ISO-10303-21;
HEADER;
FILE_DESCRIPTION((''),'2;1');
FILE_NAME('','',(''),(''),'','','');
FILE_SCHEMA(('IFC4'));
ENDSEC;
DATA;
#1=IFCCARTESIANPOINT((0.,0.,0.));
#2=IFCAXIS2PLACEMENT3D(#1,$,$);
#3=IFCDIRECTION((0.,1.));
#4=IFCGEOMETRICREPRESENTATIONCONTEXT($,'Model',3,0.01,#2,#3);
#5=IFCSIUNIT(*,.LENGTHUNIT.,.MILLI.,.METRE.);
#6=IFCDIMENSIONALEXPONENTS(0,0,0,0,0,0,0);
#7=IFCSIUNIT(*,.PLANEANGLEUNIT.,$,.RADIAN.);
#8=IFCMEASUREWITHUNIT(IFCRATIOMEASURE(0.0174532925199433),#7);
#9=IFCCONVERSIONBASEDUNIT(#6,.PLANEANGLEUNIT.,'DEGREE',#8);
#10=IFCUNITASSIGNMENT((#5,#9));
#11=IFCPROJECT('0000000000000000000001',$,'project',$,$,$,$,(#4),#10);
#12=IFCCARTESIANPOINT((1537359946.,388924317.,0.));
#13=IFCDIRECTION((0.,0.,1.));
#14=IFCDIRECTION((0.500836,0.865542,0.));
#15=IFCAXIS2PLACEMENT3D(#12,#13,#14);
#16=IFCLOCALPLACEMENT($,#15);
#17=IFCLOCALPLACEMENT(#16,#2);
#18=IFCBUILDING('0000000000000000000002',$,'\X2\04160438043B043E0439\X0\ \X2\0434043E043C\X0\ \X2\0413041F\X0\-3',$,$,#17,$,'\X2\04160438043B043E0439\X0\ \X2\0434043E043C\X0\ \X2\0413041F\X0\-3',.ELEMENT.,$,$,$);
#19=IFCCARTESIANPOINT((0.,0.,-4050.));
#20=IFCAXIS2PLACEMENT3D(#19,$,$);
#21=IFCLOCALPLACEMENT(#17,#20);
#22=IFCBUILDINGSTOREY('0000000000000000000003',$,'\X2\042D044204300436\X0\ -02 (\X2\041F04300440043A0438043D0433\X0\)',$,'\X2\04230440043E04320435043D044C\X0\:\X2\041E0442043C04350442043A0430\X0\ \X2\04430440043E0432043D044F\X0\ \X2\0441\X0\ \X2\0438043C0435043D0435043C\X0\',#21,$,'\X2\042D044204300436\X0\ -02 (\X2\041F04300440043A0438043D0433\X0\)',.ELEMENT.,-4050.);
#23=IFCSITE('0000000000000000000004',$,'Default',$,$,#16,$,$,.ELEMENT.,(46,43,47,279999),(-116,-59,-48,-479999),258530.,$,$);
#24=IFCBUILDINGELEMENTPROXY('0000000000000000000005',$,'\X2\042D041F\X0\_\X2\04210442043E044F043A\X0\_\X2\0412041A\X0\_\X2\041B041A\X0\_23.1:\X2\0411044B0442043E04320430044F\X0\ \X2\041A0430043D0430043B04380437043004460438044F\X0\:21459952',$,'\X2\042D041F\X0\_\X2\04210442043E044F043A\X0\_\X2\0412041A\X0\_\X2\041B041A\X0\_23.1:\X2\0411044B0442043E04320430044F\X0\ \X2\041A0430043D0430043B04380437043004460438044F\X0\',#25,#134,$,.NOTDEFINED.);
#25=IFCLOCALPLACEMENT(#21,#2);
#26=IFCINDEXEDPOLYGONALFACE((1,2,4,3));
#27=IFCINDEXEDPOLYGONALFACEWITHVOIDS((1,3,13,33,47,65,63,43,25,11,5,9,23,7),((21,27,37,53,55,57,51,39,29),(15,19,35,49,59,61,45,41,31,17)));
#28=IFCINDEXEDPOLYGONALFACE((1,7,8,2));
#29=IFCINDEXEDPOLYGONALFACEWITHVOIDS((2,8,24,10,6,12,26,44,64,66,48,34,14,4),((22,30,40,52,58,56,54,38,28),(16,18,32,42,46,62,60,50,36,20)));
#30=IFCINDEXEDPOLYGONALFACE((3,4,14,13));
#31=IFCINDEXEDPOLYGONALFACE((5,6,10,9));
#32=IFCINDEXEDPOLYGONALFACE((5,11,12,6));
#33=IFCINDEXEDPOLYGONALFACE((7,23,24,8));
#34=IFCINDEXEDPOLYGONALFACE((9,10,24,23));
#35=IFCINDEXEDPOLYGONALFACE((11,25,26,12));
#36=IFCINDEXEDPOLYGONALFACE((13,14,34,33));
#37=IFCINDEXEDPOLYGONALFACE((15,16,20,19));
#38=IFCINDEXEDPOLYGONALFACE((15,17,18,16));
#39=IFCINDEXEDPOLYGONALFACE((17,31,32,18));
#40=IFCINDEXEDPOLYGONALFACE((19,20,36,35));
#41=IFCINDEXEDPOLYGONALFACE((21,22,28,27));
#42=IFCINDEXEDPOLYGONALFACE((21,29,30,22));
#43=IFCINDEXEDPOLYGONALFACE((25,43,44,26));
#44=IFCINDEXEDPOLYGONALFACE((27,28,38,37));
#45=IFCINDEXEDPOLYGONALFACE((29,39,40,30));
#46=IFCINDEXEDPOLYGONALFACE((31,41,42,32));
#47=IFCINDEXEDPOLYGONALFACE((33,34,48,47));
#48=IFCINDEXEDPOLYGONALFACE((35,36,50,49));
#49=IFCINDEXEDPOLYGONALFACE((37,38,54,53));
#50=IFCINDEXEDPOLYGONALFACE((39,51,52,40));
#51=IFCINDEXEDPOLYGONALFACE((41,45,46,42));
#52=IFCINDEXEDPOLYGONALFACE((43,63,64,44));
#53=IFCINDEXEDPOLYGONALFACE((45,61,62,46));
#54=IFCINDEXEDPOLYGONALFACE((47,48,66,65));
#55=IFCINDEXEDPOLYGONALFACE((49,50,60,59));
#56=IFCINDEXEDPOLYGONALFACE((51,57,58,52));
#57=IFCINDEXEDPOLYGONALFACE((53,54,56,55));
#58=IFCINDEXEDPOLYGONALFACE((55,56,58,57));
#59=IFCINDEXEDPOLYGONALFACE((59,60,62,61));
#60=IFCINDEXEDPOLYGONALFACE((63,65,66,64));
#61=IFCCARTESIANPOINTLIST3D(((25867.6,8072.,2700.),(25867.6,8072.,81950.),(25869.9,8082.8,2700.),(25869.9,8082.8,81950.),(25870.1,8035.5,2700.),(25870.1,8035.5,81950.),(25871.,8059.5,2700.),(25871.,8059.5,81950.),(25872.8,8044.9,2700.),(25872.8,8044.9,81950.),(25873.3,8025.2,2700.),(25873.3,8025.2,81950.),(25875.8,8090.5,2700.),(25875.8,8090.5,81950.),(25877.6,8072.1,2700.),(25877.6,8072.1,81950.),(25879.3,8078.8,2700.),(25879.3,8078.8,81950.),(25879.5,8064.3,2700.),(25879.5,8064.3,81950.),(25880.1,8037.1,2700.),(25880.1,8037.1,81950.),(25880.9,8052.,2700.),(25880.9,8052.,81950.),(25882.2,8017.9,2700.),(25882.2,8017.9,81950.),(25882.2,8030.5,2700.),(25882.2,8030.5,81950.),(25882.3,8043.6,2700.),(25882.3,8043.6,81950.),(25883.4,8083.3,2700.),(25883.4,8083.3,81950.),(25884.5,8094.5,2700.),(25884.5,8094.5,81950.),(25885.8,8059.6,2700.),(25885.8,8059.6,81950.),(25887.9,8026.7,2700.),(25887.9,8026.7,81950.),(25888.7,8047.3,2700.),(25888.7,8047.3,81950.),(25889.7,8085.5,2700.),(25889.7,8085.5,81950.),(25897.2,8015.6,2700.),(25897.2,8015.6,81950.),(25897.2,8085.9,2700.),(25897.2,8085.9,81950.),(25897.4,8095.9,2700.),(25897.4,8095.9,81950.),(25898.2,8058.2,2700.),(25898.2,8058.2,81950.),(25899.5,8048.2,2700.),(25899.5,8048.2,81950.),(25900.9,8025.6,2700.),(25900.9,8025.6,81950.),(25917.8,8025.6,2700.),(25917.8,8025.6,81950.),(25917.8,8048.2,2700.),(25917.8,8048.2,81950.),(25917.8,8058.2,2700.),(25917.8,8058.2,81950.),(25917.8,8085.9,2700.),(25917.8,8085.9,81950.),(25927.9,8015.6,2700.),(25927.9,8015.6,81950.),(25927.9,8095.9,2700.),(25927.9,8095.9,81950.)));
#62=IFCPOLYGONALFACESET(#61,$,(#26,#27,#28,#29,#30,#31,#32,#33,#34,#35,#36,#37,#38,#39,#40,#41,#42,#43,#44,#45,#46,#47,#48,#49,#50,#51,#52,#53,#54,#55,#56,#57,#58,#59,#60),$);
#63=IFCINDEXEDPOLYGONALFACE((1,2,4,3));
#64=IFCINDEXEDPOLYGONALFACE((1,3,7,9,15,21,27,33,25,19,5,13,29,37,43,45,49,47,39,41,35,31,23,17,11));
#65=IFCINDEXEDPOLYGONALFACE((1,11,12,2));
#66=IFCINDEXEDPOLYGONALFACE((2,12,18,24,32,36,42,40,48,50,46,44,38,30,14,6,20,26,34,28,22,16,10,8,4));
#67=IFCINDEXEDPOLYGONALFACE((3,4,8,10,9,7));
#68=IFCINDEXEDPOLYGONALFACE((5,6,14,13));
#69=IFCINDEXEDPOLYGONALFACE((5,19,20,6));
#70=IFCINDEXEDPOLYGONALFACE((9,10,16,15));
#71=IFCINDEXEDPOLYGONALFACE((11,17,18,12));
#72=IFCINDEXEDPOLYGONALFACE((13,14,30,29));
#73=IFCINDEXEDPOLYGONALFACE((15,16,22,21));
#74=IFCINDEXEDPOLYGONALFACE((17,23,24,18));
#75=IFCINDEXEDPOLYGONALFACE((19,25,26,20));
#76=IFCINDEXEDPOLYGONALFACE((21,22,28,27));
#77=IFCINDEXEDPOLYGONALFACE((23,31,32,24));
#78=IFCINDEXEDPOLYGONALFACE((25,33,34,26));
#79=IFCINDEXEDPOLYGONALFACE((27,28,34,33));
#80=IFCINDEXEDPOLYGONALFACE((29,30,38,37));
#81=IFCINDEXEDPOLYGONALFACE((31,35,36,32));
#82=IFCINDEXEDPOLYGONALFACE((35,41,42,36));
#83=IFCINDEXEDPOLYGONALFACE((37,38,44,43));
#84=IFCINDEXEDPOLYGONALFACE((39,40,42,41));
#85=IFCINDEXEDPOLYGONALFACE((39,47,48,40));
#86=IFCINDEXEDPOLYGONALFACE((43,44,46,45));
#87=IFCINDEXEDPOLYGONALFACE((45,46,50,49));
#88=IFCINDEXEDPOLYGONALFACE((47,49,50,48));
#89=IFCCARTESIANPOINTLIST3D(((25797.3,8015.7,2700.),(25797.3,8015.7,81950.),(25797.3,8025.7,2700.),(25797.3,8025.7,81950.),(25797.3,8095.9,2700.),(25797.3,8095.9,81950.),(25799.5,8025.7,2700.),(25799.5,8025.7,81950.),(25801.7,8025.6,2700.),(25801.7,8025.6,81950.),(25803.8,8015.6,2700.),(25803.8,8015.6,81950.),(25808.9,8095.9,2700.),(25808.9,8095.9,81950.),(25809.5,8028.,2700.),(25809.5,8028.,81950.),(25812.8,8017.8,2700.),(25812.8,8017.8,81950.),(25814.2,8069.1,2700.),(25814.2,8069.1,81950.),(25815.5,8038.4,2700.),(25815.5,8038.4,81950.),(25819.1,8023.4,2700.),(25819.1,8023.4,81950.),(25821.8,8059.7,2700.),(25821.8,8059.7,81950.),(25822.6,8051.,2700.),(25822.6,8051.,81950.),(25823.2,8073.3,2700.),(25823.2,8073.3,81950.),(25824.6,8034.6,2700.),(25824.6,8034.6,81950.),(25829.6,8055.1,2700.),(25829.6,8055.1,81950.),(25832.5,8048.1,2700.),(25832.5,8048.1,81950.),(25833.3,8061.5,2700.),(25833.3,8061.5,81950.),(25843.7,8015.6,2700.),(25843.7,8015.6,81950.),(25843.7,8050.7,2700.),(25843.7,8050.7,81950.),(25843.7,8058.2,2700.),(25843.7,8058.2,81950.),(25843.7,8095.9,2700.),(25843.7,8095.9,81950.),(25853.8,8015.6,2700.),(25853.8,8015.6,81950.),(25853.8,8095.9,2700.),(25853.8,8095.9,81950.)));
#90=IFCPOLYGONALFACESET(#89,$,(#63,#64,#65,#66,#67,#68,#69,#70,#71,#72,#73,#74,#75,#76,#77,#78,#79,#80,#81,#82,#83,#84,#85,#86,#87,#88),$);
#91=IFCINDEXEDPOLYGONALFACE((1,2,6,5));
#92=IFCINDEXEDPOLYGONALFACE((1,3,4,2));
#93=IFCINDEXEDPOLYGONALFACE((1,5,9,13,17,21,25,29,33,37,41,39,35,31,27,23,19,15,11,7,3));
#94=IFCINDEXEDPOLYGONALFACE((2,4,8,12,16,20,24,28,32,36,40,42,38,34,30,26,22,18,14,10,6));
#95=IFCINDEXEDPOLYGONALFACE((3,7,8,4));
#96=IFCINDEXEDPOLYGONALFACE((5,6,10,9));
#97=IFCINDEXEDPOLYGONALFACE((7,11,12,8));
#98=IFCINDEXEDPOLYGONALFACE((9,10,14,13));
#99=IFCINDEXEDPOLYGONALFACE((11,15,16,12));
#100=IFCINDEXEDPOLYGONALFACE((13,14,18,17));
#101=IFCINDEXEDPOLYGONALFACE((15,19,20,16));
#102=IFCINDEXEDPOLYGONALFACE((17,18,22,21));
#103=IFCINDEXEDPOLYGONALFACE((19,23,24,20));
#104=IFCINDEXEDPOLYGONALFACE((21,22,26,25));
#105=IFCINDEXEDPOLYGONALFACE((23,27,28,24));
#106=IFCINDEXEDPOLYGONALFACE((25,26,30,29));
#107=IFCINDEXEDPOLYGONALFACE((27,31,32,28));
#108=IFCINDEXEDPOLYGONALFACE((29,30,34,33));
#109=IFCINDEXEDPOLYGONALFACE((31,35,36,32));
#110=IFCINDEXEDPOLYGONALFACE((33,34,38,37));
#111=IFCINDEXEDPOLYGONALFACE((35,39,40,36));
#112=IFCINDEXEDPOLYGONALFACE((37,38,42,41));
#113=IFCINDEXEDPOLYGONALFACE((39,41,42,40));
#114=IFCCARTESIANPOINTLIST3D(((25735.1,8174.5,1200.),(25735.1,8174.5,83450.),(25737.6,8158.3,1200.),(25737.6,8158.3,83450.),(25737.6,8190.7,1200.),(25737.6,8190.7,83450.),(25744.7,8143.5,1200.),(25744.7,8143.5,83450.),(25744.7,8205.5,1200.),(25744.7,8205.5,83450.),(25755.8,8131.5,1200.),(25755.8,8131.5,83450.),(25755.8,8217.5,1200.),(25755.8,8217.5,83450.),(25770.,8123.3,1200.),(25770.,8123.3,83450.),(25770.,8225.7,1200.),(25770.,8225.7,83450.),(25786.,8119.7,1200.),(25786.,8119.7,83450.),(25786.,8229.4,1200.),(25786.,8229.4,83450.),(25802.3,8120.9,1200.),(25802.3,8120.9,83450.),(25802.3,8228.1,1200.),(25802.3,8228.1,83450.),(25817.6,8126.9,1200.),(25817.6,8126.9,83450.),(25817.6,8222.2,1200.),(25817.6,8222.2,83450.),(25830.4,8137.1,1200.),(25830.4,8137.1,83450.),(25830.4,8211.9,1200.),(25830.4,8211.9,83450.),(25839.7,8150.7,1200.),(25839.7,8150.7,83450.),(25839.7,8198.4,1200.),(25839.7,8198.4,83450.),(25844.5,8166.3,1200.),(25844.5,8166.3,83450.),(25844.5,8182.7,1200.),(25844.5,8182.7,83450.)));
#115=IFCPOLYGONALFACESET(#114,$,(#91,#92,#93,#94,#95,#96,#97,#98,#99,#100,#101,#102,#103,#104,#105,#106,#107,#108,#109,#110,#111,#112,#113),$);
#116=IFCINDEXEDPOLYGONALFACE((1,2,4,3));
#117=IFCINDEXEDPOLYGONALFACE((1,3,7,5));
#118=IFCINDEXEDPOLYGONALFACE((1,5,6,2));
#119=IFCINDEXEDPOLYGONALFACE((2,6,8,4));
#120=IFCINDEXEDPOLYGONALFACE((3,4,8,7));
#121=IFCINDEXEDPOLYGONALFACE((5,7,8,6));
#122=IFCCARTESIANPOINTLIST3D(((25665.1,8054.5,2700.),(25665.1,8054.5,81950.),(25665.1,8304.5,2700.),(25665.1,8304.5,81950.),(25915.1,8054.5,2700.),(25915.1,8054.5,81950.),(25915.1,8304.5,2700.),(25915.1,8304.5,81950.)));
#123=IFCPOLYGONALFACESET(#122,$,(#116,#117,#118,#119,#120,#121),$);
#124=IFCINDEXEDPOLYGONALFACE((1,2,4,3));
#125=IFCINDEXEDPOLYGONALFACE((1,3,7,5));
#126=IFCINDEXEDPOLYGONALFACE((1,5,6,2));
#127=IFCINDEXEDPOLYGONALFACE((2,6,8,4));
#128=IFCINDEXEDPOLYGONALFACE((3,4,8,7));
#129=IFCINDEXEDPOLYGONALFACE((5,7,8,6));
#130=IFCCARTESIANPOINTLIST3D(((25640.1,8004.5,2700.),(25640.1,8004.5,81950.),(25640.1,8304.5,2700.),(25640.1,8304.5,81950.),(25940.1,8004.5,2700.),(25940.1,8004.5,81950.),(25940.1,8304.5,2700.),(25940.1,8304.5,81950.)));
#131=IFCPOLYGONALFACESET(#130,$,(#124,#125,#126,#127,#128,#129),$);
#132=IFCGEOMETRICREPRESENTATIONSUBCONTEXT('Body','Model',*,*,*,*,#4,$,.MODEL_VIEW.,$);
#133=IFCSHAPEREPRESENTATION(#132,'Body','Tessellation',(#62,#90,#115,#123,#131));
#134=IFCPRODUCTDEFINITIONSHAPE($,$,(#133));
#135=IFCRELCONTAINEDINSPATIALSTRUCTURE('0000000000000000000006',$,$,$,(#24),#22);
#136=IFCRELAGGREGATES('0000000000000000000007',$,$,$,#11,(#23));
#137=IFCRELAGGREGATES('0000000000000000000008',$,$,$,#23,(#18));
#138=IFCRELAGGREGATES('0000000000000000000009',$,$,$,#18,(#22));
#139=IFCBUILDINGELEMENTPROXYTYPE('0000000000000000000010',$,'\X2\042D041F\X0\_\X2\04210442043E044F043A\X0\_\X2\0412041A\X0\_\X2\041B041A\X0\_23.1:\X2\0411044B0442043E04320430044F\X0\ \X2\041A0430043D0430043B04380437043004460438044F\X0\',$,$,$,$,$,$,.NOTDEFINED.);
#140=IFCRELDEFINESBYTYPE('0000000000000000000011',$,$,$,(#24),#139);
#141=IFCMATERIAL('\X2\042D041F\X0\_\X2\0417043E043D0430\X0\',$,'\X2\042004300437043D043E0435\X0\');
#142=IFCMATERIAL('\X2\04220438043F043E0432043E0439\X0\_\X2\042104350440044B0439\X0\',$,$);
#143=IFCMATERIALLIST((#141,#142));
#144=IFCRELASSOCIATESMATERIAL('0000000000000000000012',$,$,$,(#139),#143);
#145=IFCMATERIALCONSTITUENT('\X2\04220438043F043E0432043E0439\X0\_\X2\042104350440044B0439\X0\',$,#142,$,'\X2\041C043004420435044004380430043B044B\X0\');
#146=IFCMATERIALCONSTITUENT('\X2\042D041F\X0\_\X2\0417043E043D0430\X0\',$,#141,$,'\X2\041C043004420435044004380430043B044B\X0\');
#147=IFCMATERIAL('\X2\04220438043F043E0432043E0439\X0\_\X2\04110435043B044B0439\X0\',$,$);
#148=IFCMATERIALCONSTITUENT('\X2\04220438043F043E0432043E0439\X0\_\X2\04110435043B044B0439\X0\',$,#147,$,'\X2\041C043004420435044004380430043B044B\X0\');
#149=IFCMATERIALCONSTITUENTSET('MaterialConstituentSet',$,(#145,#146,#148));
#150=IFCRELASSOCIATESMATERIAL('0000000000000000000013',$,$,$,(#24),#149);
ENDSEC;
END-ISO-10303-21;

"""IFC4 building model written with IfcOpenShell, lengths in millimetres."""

from ifc_helpers import new_model, entity, si_unit, converted_unit, direction, frame, frame_2d, origin, place, context, subcontext, project, spatial, polyline, rectangle, circle, outline, extrude, source, transform, mapped, material, material_list, constituent, constituent_set, type_object, type_shapes, element, save


model = new_model("IFC4")

# Units and contexts
model_context = context("Model", 3, precision=0.01, world=origin(), true_north=direction((0.0, 1.0)))
body_context = subcontext(model_context, "Body", "Model", "MODEL_VIEW")
ifc_project = project(units=[si_unit("LENGTHUNIT", "METRE", prefix="MILLI"), converted_unit("PLANEANGLEUNIT", "DEGREE", entity("IfcRatioMeasure", 0.0174532925199433), si_unit("PLANEANGLEUNIT", "RADIAN"), dimensions=[0, 0, 0, 0, 0, 0, 0])], contexts=[model_context])

# Site, building, storey
site_placement = place(None, frame((1537359946.0, 388924317.0, 0.0), z_axis=(0.0, 0.0, 1.0), x_axis=(0.500836, 0.865542, 0.0)))
site = spatial("IfcSite", under=ifc_project, at=site_placement, Name="Default", CompositionType="ELEMENT", RefLatitude=(46, 43, 47, 279999), RefLongitude=(-116, -59, -48, -479999), RefElevation=258530.0)
building_placement = place(site_placement, origin())
building = spatial("IfcBuilding", under=site, at=building_placement, Name="Жилой дом ГП-3", LongName="Жилой дом ГП-3", CompositionType="ELEMENT")
storey_placement = place(building_placement, frame((0.0, 0.0, -4050.0)))
storey = spatial("IfcBuildingStorey", under=building, at=storey_placement, Name="Этаж -02 (Паркинг)", ObjectType="Уровень:Отметка уровня с именем", LongName="Этаж -02 (Паркинг)", CompositionType="ELEMENT", Elevation=-4050.0)

# Building element proxy
ifc_material_1 = material(Name="ЭП_Зона", Category="Разное")
ifc_material_2 = material(Name="Типовой_Белый")
ifc_material_3 = material(Name="Типовой_Серый")
ifc_constituent_1 = constituent(ifc_material_3, Name="Типовой_Серый", Category="Материалы")
ifc_constituent_2 = constituent(ifc_material_1, Name="ЭП_Зона", Category="Материалы")
ifc_constituent_3 = constituent(ifc_material_2, Name="Типовой_Белый", Category="Материалы")
ifc_constituent_set_1 = constituent_set(constituents=[ifc_constituent_1, ifc_constituent_2, ifc_constituent_3], Name="MaterialConstituentSet")
ifc_material_list_1 = material_list([ifc_material_1, ifc_material_3])
building_element_proxy_type_1 = type_object("IfcBuildingElementProxyType", Name="ЭП_Стояк_ВК_ЛК_23.1:Бытовая Канализация", PredefinedType="NOTDEFINED", material=ifc_material_list_1)
shared_shape_1 = source(origin(), body_context, "Body", "SweptSolid", [
    extrude(outline(polyline([(-42.2, -39.0), (-11.8, -39.0), (1.1, -37.6), (9.8, -33.5), (15.7, -25.8), (18.0, -15.0), (14.6, -2.5), (4.7, 5.0), (12.8, 12.1), (15.5, 21.5), (12.3, 31.8), (3.4, 39.0), (-11.6, 41.4), (-42.2, 41.4), (-42.2, -39.0)]), holes=[polyline([(-32.2, 8.8), (-32.2, 31.4), (-15.2, 31.4), (-2.3, 30.3), (3.5, 26.4), (5.5, 19.9), (3.3, 13.3), (-3.1, 9.6), (-13.9, 8.8), (-32.2, 8.8)]), polyline([(-32.2, -28.9), (-32.2, -1.3), (-12.6, -1.3), (-0.2, -2.6), (6.1, -7.3), (8.0, -15.1), (6.3, -21.9), (2.2, -26.3), (-4.1, -28.5), (-11.6, -28.9), (-32.2, -28.9)])]), frame((54.5, -52.4, -1350.0)), (0.0, 0.0, 1.0), 79250.0),
    extrude(outline(polyline([(-32.1, -31.9), (48.3, -31.9), (48.3, -21.8), (10.6, -21.8), (13.8, -11.4), (25.6, -1.3), (48.3, 13.0), (48.3, 24.6), (21.4, 7.7), (12.0, 0.1), (7.4, -7.7), (3.3, -0.7), (-9.3, 6.4), (-19.7, 12.3), (-22.1, 20.2), (-22.0, 22.4), (-22.0, 24.6), (-32.0, 24.6), (-32.1, 18.0), (-29.9, 9.0), (-24.3, 2.8), (-13.1, -2.8), (0.4, -10.6), (3.0, -21.8), (-32.1, -21.8), (-32.1, -31.9)])), frame((118.2, -43.1, -1350.0), z_axis=(0.0, 0.0, 1.0), x_axis=(0.0, -1.0, 0.0)), (0.0, 0.0, 1.0), 79250.0),
    extrude(circle(Radius=55.0, at=frame_2d((0.0, 0.0), x_axis=(1.0, 0.0))), frame((150.0, -170.0, -2850.0)), (0.0, 0.0, 1.0), 82250.0),
    extrude(rectangle(XDim=250.0, YDim=250.0, at=frame_2d((0.0, 0.0), x_axis=(1.0, 0.0))), frame((150.0, -175.0, -1350.0)), (0.0, 0.0, 1.0), 79250.0),
    extrude(rectangle(XDim=300.0, YDim=300.0, at=frame_2d((0.0, 0.0), x_axis=(1.0, 0.0))), frame((150.0, -150.0, -1350.0)), (0.0, 0.0, 1.0), 79250.0),
])
type_shapes(building_element_proxy_type_1, [shared_shape_1])
proxy_1_placement = place(storey_placement, frame((25940.1, 8004.5, 4050.0), z_axis=(0.0, 0.0, 1.0), x_axis=(-1.0, 0.0, 0.0)))
element("IfcBuildingElementProxy", 1, at=proxy_1_placement, inside=storey, type_object=building_element_proxy_type_1, material=ifc_constituent_set_1, Name="ЭП_Стояк_ВК_ЛК_23.1:Бытовая Канализация:21459952", ObjectType="ЭП_Стояк_ВК_ЛК_23.1:Бытовая Канализация", PredefinedType="NOTDEFINED", context=body_context, shape_type="MappedRepresentation", body=[
    mapped(shared_shape_1, transform((0.0, 0.0, 0.0), scale=1.0)),
])

save(model, "model.ifc")
